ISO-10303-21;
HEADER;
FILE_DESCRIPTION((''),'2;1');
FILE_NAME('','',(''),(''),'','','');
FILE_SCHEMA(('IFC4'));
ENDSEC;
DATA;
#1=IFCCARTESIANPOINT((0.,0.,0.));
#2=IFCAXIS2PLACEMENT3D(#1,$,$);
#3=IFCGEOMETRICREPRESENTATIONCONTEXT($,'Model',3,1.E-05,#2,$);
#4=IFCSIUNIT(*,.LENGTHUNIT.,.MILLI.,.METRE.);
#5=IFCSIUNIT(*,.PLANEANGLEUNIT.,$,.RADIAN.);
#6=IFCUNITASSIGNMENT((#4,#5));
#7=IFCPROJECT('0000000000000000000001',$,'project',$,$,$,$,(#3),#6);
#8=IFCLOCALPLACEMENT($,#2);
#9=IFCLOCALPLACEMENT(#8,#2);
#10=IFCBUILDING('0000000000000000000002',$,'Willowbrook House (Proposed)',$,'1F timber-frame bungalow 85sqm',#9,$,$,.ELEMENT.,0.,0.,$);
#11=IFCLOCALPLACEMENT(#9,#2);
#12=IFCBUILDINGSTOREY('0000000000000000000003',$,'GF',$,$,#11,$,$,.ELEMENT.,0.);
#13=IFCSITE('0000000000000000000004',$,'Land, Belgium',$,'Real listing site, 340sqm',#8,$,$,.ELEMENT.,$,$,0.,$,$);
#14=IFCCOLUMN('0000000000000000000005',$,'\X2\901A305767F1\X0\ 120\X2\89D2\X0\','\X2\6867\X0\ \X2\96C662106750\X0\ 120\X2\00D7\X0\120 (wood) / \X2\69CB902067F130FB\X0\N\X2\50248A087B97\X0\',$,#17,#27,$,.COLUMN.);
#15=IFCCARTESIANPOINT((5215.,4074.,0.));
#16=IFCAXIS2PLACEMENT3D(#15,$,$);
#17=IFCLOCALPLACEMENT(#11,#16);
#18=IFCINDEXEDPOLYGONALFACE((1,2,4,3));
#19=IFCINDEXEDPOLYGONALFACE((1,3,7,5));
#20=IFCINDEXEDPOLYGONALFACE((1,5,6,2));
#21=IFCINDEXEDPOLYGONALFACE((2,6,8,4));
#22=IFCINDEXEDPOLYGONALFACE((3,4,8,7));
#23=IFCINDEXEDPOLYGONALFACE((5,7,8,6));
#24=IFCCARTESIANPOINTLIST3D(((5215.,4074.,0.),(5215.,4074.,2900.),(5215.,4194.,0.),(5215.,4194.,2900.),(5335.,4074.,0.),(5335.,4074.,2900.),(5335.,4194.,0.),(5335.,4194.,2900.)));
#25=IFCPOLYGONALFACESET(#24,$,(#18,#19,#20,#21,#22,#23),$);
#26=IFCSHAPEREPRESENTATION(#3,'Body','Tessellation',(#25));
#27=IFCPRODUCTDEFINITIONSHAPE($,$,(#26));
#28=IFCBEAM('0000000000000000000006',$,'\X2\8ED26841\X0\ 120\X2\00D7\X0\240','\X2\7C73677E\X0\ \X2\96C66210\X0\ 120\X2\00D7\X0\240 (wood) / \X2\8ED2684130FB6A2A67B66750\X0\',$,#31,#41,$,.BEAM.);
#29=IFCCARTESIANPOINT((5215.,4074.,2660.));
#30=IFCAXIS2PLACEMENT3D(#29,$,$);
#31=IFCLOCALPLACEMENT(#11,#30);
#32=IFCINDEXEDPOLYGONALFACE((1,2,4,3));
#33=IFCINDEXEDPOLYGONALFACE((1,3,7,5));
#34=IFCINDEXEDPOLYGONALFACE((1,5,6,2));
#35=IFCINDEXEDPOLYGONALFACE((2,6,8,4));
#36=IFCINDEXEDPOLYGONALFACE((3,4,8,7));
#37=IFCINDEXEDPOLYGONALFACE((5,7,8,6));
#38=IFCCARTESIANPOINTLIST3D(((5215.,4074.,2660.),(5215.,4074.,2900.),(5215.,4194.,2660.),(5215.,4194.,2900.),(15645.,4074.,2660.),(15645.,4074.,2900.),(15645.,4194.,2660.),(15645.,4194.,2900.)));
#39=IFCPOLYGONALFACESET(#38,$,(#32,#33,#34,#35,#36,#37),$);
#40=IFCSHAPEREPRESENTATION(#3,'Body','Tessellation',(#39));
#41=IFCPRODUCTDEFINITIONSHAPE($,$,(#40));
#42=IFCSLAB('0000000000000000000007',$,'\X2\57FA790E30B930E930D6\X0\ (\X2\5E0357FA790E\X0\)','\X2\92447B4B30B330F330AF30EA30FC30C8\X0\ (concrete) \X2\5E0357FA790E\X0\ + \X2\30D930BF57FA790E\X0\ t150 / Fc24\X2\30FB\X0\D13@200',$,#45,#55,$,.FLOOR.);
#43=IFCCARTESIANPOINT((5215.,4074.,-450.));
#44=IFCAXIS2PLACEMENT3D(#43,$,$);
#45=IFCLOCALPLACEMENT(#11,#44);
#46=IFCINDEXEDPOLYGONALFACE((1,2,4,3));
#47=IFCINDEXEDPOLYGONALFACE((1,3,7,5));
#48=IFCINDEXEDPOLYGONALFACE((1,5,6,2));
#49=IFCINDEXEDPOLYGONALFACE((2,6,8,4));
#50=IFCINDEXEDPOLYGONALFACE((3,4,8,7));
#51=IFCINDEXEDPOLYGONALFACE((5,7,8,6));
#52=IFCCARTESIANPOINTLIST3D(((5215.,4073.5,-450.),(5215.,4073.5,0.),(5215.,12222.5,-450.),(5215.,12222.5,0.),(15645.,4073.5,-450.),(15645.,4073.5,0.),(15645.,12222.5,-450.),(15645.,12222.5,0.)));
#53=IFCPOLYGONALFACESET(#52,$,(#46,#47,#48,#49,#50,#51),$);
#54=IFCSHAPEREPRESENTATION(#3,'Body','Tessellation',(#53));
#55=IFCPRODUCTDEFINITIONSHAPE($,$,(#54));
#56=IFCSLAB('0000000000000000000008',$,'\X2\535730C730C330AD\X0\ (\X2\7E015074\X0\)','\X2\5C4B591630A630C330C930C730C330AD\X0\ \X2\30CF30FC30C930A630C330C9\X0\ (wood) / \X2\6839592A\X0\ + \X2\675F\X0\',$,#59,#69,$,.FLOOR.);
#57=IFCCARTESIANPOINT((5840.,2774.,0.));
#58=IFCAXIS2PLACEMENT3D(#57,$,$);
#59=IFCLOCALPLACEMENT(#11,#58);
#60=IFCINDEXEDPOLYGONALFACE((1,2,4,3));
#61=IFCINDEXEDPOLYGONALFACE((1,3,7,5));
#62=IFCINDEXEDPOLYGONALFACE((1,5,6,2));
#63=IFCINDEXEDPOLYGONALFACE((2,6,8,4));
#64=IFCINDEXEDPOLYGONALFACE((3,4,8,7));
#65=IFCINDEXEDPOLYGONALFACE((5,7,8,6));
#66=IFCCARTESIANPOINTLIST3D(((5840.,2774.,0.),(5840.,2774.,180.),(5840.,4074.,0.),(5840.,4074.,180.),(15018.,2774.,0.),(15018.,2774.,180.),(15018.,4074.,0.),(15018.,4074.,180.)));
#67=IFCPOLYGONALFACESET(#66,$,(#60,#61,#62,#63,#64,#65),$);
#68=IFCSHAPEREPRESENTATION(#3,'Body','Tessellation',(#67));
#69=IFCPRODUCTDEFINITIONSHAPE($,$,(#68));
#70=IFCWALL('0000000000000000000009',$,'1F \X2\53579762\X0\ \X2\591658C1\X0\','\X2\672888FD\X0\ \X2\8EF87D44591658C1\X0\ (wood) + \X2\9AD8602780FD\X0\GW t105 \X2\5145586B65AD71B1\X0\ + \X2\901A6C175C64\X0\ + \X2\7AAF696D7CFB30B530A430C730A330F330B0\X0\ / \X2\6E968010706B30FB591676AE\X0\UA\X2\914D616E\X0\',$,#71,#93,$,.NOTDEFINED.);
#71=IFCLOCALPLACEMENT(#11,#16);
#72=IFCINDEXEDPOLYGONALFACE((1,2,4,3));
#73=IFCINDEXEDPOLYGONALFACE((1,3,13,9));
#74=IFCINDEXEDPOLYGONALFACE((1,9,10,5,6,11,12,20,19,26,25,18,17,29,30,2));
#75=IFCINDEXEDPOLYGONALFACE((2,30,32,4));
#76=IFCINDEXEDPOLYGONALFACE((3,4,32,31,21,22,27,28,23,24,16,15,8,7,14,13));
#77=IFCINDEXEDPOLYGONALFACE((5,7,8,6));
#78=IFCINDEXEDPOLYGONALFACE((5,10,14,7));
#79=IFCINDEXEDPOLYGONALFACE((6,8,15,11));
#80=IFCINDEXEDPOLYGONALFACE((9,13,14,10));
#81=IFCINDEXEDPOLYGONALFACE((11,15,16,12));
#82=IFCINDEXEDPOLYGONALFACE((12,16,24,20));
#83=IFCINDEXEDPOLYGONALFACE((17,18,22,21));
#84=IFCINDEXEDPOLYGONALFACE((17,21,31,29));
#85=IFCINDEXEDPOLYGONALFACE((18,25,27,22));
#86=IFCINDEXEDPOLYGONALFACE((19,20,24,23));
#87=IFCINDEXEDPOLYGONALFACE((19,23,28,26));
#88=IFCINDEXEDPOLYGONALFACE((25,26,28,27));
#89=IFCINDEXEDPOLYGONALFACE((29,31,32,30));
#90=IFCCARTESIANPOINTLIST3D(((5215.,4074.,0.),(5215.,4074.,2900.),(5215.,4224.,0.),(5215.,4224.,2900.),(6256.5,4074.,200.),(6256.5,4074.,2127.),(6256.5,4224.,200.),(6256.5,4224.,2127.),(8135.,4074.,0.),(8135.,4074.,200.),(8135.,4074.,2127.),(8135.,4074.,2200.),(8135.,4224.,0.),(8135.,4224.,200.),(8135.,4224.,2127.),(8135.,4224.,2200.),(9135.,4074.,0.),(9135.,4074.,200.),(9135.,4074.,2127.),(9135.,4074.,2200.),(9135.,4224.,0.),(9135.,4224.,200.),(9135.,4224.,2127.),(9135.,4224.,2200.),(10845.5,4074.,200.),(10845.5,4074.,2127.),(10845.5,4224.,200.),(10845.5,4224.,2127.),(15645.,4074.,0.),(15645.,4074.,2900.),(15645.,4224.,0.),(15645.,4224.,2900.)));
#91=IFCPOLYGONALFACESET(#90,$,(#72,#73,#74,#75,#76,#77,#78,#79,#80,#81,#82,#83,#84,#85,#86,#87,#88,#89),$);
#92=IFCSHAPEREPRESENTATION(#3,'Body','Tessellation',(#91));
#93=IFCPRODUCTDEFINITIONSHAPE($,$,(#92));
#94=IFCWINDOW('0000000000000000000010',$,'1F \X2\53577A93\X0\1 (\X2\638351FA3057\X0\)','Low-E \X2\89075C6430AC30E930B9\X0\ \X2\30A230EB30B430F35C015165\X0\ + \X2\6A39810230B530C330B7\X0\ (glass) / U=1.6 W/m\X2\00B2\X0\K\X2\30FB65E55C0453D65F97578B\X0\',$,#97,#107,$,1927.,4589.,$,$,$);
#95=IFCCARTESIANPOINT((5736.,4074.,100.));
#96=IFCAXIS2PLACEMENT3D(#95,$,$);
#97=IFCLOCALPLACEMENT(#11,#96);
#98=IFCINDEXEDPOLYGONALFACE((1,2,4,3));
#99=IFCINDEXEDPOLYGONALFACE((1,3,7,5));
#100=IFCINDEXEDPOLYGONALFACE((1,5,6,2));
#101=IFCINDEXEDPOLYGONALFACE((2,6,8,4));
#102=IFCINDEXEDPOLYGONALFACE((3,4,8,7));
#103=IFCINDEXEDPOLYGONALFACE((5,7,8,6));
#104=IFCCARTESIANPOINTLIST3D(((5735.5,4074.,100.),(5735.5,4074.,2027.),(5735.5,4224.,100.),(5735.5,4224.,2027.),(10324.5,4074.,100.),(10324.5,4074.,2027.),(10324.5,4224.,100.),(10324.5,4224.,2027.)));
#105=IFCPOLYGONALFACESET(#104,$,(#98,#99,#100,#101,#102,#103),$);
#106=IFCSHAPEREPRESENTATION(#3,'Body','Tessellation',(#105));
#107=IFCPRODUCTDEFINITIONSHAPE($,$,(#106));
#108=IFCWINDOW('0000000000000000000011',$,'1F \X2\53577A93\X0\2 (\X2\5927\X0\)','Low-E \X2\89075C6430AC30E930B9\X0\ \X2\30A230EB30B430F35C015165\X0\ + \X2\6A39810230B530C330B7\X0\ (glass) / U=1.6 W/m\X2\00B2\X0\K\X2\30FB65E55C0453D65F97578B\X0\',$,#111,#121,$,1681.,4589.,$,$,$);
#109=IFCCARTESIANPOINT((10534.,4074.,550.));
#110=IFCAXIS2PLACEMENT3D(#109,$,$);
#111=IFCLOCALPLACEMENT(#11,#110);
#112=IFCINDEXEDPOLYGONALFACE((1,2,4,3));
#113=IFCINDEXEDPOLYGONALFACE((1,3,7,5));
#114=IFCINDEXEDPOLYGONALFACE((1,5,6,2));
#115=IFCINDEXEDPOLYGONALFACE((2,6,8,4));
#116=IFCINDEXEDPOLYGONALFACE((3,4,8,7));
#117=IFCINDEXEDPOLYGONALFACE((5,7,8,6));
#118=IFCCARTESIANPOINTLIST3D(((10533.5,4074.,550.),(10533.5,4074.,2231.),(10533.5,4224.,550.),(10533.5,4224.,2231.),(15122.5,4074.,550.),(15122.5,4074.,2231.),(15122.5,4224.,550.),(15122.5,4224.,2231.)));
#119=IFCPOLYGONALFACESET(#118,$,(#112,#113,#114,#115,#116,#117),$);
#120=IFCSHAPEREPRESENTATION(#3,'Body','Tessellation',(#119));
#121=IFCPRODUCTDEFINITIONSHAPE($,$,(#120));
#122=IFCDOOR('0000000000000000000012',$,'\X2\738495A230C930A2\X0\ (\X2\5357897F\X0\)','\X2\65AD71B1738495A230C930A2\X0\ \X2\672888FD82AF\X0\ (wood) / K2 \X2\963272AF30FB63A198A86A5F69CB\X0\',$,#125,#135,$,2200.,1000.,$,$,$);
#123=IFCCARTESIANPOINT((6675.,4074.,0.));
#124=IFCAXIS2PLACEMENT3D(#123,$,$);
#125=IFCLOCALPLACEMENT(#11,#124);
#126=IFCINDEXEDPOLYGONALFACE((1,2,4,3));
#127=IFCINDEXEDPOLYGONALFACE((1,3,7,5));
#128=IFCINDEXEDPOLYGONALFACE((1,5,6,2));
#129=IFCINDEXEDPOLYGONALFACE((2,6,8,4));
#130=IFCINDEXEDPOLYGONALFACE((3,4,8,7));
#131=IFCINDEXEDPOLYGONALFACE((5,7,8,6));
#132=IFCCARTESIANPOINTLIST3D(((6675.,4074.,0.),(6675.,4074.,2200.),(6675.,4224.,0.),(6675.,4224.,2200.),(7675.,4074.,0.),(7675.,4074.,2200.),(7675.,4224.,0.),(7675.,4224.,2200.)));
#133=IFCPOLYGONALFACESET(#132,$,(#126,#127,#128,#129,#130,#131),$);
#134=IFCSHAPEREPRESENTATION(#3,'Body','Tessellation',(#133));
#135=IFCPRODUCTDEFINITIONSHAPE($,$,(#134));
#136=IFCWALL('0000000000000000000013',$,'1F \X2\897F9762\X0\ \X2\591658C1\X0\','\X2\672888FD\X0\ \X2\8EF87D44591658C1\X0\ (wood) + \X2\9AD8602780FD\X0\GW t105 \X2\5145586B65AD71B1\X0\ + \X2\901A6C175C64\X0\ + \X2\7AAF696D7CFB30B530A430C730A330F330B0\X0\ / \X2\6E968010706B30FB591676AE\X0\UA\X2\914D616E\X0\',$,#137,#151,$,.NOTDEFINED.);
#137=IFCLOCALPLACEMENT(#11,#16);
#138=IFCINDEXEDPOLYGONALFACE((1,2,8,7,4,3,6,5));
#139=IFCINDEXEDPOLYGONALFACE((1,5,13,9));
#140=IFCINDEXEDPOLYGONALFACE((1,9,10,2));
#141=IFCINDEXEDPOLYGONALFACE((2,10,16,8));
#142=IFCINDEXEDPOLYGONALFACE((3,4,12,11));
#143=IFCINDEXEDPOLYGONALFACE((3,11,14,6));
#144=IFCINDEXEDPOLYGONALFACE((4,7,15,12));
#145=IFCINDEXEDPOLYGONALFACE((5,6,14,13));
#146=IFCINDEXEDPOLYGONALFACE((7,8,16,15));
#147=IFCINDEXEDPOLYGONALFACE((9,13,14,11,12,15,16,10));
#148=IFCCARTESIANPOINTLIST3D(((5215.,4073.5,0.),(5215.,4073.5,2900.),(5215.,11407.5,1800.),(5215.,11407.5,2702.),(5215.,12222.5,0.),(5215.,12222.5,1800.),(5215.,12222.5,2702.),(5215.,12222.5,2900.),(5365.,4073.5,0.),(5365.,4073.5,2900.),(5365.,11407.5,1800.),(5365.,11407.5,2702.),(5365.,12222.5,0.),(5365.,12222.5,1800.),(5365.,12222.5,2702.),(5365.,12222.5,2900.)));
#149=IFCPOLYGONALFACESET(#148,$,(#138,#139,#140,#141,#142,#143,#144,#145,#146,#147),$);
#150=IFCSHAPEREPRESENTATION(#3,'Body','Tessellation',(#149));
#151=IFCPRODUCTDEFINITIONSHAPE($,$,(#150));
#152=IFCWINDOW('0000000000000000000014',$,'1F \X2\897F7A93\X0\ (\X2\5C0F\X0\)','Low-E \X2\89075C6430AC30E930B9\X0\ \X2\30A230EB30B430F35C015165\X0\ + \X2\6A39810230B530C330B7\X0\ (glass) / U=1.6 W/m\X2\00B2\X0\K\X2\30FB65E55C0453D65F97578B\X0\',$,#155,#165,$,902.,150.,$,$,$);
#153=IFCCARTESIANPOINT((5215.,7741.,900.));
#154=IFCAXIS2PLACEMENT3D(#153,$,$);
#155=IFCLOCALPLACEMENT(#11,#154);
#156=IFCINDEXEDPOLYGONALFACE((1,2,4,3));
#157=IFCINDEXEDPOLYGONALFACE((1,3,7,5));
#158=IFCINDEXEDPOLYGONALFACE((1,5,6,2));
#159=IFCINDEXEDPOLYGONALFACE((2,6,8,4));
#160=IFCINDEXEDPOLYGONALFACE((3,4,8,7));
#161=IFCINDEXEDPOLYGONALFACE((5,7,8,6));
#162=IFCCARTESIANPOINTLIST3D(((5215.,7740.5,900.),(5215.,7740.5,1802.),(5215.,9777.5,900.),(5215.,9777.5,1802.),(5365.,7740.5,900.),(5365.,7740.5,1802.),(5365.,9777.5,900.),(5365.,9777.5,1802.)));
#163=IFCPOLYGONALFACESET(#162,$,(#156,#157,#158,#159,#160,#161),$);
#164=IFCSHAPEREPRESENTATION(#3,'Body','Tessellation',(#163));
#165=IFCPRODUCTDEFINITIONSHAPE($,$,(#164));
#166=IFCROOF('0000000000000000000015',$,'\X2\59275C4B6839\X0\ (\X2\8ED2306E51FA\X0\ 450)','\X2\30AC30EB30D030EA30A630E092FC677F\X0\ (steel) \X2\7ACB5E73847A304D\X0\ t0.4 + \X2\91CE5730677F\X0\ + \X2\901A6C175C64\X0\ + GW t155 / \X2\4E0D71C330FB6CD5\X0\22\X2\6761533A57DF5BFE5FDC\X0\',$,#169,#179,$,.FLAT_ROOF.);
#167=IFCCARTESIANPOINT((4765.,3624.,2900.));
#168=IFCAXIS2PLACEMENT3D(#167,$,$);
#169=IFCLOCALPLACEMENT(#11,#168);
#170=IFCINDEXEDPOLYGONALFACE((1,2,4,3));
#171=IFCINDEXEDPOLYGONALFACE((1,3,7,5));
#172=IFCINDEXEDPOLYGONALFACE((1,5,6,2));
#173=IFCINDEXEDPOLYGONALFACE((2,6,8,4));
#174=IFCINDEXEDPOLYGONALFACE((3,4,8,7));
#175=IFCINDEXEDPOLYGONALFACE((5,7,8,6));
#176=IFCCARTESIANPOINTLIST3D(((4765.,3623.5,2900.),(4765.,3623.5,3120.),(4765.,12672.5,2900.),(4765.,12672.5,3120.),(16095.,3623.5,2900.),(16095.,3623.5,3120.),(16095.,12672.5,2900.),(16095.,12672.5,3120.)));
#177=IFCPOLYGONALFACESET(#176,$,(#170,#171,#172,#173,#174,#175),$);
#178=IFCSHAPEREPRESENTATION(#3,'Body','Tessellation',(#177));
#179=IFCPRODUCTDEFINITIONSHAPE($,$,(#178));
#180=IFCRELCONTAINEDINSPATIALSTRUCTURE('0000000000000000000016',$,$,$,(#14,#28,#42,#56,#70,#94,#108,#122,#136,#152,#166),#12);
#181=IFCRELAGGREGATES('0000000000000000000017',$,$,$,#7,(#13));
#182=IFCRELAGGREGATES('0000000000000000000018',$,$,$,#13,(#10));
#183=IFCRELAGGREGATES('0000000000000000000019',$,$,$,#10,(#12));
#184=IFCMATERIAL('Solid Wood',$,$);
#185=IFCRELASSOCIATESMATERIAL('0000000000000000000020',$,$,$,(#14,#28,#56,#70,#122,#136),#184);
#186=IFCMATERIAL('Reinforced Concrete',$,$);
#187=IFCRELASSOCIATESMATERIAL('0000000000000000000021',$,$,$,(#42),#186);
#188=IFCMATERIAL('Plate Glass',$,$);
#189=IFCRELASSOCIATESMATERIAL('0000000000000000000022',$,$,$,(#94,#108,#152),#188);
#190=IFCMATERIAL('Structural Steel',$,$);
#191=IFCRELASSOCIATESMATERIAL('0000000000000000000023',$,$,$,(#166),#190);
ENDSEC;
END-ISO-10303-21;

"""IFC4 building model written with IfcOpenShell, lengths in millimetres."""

from ifc_helpers import new_model, si_unit, frame, frame_2d, origin, place, context, project, spatial, rectangle, extrude, material, element, fill, save


model = new_model("IFC4")

# Units and contexts
model_context = context("Model", 3, precision=1e-05, world=origin())
ifc_project = project(units=[si_unit("LENGTHUNIT", "METRE", prefix="MILLI"), si_unit("PLANEANGLEUNIT", "RADIAN")], contexts=[model_context])

# Site, building, storey
site_placement = place(None, origin())
site = spatial("IfcSite", under=ifc_project, at=site_placement, Name="Land, Belgium", ObjectType="Real listing site, 340sqm", CompositionType="ELEMENT", RefElevation=0.0)
building_placement = place(site_placement, origin())
building = spatial("IfcBuilding", under=site, at=building_placement, Name="Willowbrook House (Proposed)", ObjectType="1F timber-frame bungalow 85sqm", CompositionType="ELEMENT", ElevationOfRefHeight=0.0, ElevationOfTerrain=0.0)
storey_placement = place(building_placement, origin())
storey = spatial("IfcBuildingStorey", under=building, at=storey_placement, Name="GF", CompositionType="ELEMENT", Elevation=0.0)

# Column
ifc_material_1 = material(Name="Solid Wood")
column_1_placement = place(storey_placement, frame((5215.0, 4074.0, 0.0)))
element("IfcColumn", 1, at=column_1_placement, inside=storey, material=ifc_material_1, Name="通し柱 120角", Description="桧 集成材 120×120 (wood) / 構造柱・N値計算", PredefinedType="COLUMN", context=model_context, shape_type="SweptSolid", body=[
    extrude(rectangle(XDim=120.0, YDim=120.0, at=frame_2d((60.0, 60.0))), frame((5215.0, 4074.0, 0.0)), (0.0, 0.0, 1.0), 2900.0),
])

# Beam
beam_1_placement = place(storey_placement, frame((5215.0, 4074.0, 2660.0)))
element("IfcBeam", 2, at=beam_1_placement, inside=storey, material=ifc_material_1, Name="軒桁 120×240", Description="米松 集成 120×240 (wood) / 軒桁・横架材", PredefinedType="BEAM", context=model_context, shape_type="SweptSolid", body=[
    extrude(rectangle(XDim=10430.0, YDim=120.0, at=frame_2d((5215.0, 60.0))), frame((5215.0, 4074.0, 2660.0)), (0.0, 0.0, 1.0), 240.0),
])

# Slabs
ifc_material_2 = material(Name="Reinforced Concrete")
slab_1_placement = place(storey_placement, frame((5215.0, 4074.0, -450.0)))
element("IfcSlab", 3, at=slab_1_placement, inside=storey, material=ifc_material_2, Name="基礎スラブ (布基礎)", Description="鉄筋コンクリート (concrete) 布基礎 + ベタ基礎 t150 / Fc24・D13@200", PredefinedType="FLOOR", context=model_context, shape_type="SweptSolid", body=[
    extrude(rectangle(XDim=10430.0, YDim=8149.0, at=frame_2d((5215.0, 4074.0))), frame((5215.0, 4074.0, -450.0)), (0.0, 0.0, 1.0), 450.0),
])
slab_2_placement = place(storey_placement, frame((5840.0, 2774.0, 0.0)))
element("IfcSlab", 4, at=slab_2_placement, inside=storey, material=ifc_material_1, Name="南デッキ (縁側)", Description="屋外ウッドデッキ ハードウッド (wood) / 根太 + 束", PredefinedType="FLOOR", context=model_context, shape_type="SweptSolid", body=[
    extrude(rectangle(XDim=9178.0, YDim=1300.0, at=frame_2d((4589.0, 650.0))), frame((5840.0, 2774.0, 0.0)), (0.0, 0.0, 1.0), 180.0),
])

# Wall, openings, windows, door
wall_1_placement = place(storey_placement, frame((5215.0, 4074.0, 0.0)))
wall_1 = element("IfcWall", 5, at=wall_1_placement, inside=storey, material=ifc_material_1, Name="1F 南面 外壁", Description="木製 軸組外壁 (wood) + 高性能GW t105 充填断熱 + 通気層 + 窯業系サイディング / 準耐火・外皮UA配慮", PredefinedType="NOTDEFINED", context=model_context, shape_type="SweptSolid", body=[
    extrude(rectangle(XDim=10430.0, YDim=150.0, at=frame_2d((5215.0, 75.0))), frame((5215.0, 4074.0, 0.0)), (0.0, 0.0, 1.0), 2900.0),
])
opening_1_placement = place(storey_placement, frame((5736.0, 4074.0, 100.0)))
opening_1 = element("IfcOpeningElement", 6, at=opening_1_placement, cuts=wall_1, PredefinedType="NOTDEFINED", context=model_context, shape_type="SweptSolid", body=[
    extrude(rectangle(XDim=4589.0, YDim=150.0, at=frame_2d((2294.0, 75.0))), frame((5736.0, 4074.0, 100.0)), (0.0, 0.0, 1.0), 1927.0),
])
opening_2_placement = place(storey_placement, frame((10534.0, 4074.0, 550.0)))
opening_2 = element("IfcOpeningElement", 7, at=opening_2_placement, cuts=wall_1, PredefinedType="NOTDEFINED", context=model_context, shape_type="SweptSolid", body=[
    extrude(rectangle(XDim=4589.0, YDim=150.0, at=frame_2d((2294.0, 75.0))), frame((10534.0, 4074.0, 550.0)), (0.0, 0.0, 1.0), 1681.0),
])
opening_3_placement = place(storey_placement, frame((6675.0, 4074.0, 0.0)))
opening_3 = element("IfcOpeningElement", 8, at=opening_3_placement, cuts=wall_1, PredefinedType="NOTDEFINED", context=model_context, shape_type="SweptSolid", body=[
    extrude(rectangle(XDim=1000.0, YDim=150.0, at=frame_2d((500.0, 75.0))), frame((6675.0, 4074.0, 0.0)), (0.0, 0.0, 1.0), 2200.0),
])
ifc_material_3 = material(Name="Plate Glass")
window_1_placement = place(storey_placement, frame((5736.0, 4074.0, 100.0)))
window_1 = element("IfcWindow", 9, at=window_1_placement, inside=storey, material=ifc_material_3, Name="1F 南窓1 (掃出し)", Description="Low-E 複層ガラス アルゴン封入 + 樹脂サッシ (glass) / U=1.6 W/m²K・日射取得型", OverallHeight=1927.0, OverallWidth=4589.0, context=model_context, shape_type="SweptSolid", body=[
    extrude(rectangle(XDim=4589.0, YDim=150.0, at=frame_2d((2294.0, 75.0))), frame((5736.0, 4074.0, 100.0)), (0.0, 0.0, 1.0), 1927.0),
])
fill(opening_1, window_1)
window_2_placement = place(storey_placement, frame((10534.0, 4074.0, 550.0)))
window_2 = element("IfcWindow", 10, at=window_2_placement, inside=storey, material=ifc_material_3, Name="1F 南窓2 (大)", Description="Low-E 複層ガラス アルゴン封入 + 樹脂サッシ (glass) / U=1.6 W/m²K・日射取得型", OverallHeight=1681.0, OverallWidth=4589.0, context=model_context, shape_type="SweptSolid", body=[
    extrude(rectangle(XDim=4589.0, YDim=150.0, at=frame_2d((2294.0, 75.0))), frame((10534.0, 4074.0, 550.0)), (0.0, 0.0, 1.0), 1681.0),
])
fill(opening_2, window_2)
door_placement = place(storey_placement, frame((6675.0, 4074.0, 0.0)))
door = element("IfcDoor", 11, at=door_placement, inside=storey, material=ifc_material_1, Name="玄関ドア (南西)", Description="断熱玄関ドア 木製芯 (wood) / K2 防犯・採風機構", OverallHeight=2200.0, OverallWidth=1000.0, context=model_context, shape_type="SweptSolid", body=[
    extrude(rectangle(XDim=1000.0, YDim=150.0, at=frame_2d((500.0, 75.0))), frame((6675.0, 4074.0, 0.0)), (0.0, 0.0, 1.0), 2200.0),
])
fill(opening_3, door)

# Wall, opening, window
wall_2_placement = place(storey_placement, frame((5215.0, 4074.0, 0.0)))
wall_2 = element("IfcWall", 12, at=wall_2_placement, inside=storey, material=ifc_material_1, Name="1F 西面 外壁", Description="木製 軸組外壁 (wood) + 高性能GW t105 充填断熱 + 通気層 + 窯業系サイディング / 準耐火・外皮UA配慮", PredefinedType="NOTDEFINED", context=model_context, shape_type="SweptSolid", body=[
    extrude(rectangle(XDim=150.0, YDim=8149.0, at=frame_2d((75.0, 4074.0))), frame((5215.0, 4074.0, 0.0)), (0.0, 0.0, 1.0), 2900.0),
])
opening_4_placement = place(storey_placement, frame((5215.0, 7741.0, 900.0)))
opening_4 = element("IfcOpeningElement", 13, at=opening_4_placement, cuts=wall_2, PredefinedType="NOTDEFINED", context=model_context, shape_type="SweptSolid", body=[
    extrude(rectangle(XDim=150.0, YDim=2037.0, at=frame_2d((75.0, 1018.0))), frame((5215.0, 7741.0, 900.0)), (0.0, 0.0, 1.0), 902.0),
])
window_3_placement = place(storey_placement, frame((5215.0, 7741.0, 900.0)))
window_3 = element("IfcWindow", 14, at=window_3_placement, inside=storey, material=ifc_material_3, Name="1F 西窓 (小)", Description="Low-E 複層ガラス アルゴン封入 + 樹脂サッシ (glass) / U=1.6 W/m²K・日射取得型", OverallHeight=902.0, OverallWidth=150.0, context=model_context, shape_type="SweptSolid", body=[
    extrude(rectangle(XDim=150.0, YDim=2037.0, at=frame_2d((75.0, 1018.0))), frame((5215.0, 7741.0, 900.0)), (0.0, 0.0, 1.0), 902.0),
])
fill(opening_4, window_3)

# Roof
ifc_material_4 = material(Name="Structural Steel")
roof_placement = place(storey_placement, frame((4765.0, 3624.0, 2900.0)))
element("IfcRoof", 15, at=roof_placement, inside=storey, material=ifc_material_4, Name="大屋根 (軒の出 450)", Description="ガルバリウム鋼板 (steel) 立平葺き t0.4 + 野地板 + 通気層 + GW t155 / 不燃・法22条区域対応", PredefinedType="FLAT_ROOF", context=model_context, shape_type="SweptSolid", body=[
    extrude(rectangle(XDim=11330.0, YDim=9049.0, at=frame_2d((5665.0, 4524.0))), frame((4765.0, 3624.0, 2900.0)), (0.0, 0.0, 1.0), 220.0),
])

save(model, "model.ifc")
